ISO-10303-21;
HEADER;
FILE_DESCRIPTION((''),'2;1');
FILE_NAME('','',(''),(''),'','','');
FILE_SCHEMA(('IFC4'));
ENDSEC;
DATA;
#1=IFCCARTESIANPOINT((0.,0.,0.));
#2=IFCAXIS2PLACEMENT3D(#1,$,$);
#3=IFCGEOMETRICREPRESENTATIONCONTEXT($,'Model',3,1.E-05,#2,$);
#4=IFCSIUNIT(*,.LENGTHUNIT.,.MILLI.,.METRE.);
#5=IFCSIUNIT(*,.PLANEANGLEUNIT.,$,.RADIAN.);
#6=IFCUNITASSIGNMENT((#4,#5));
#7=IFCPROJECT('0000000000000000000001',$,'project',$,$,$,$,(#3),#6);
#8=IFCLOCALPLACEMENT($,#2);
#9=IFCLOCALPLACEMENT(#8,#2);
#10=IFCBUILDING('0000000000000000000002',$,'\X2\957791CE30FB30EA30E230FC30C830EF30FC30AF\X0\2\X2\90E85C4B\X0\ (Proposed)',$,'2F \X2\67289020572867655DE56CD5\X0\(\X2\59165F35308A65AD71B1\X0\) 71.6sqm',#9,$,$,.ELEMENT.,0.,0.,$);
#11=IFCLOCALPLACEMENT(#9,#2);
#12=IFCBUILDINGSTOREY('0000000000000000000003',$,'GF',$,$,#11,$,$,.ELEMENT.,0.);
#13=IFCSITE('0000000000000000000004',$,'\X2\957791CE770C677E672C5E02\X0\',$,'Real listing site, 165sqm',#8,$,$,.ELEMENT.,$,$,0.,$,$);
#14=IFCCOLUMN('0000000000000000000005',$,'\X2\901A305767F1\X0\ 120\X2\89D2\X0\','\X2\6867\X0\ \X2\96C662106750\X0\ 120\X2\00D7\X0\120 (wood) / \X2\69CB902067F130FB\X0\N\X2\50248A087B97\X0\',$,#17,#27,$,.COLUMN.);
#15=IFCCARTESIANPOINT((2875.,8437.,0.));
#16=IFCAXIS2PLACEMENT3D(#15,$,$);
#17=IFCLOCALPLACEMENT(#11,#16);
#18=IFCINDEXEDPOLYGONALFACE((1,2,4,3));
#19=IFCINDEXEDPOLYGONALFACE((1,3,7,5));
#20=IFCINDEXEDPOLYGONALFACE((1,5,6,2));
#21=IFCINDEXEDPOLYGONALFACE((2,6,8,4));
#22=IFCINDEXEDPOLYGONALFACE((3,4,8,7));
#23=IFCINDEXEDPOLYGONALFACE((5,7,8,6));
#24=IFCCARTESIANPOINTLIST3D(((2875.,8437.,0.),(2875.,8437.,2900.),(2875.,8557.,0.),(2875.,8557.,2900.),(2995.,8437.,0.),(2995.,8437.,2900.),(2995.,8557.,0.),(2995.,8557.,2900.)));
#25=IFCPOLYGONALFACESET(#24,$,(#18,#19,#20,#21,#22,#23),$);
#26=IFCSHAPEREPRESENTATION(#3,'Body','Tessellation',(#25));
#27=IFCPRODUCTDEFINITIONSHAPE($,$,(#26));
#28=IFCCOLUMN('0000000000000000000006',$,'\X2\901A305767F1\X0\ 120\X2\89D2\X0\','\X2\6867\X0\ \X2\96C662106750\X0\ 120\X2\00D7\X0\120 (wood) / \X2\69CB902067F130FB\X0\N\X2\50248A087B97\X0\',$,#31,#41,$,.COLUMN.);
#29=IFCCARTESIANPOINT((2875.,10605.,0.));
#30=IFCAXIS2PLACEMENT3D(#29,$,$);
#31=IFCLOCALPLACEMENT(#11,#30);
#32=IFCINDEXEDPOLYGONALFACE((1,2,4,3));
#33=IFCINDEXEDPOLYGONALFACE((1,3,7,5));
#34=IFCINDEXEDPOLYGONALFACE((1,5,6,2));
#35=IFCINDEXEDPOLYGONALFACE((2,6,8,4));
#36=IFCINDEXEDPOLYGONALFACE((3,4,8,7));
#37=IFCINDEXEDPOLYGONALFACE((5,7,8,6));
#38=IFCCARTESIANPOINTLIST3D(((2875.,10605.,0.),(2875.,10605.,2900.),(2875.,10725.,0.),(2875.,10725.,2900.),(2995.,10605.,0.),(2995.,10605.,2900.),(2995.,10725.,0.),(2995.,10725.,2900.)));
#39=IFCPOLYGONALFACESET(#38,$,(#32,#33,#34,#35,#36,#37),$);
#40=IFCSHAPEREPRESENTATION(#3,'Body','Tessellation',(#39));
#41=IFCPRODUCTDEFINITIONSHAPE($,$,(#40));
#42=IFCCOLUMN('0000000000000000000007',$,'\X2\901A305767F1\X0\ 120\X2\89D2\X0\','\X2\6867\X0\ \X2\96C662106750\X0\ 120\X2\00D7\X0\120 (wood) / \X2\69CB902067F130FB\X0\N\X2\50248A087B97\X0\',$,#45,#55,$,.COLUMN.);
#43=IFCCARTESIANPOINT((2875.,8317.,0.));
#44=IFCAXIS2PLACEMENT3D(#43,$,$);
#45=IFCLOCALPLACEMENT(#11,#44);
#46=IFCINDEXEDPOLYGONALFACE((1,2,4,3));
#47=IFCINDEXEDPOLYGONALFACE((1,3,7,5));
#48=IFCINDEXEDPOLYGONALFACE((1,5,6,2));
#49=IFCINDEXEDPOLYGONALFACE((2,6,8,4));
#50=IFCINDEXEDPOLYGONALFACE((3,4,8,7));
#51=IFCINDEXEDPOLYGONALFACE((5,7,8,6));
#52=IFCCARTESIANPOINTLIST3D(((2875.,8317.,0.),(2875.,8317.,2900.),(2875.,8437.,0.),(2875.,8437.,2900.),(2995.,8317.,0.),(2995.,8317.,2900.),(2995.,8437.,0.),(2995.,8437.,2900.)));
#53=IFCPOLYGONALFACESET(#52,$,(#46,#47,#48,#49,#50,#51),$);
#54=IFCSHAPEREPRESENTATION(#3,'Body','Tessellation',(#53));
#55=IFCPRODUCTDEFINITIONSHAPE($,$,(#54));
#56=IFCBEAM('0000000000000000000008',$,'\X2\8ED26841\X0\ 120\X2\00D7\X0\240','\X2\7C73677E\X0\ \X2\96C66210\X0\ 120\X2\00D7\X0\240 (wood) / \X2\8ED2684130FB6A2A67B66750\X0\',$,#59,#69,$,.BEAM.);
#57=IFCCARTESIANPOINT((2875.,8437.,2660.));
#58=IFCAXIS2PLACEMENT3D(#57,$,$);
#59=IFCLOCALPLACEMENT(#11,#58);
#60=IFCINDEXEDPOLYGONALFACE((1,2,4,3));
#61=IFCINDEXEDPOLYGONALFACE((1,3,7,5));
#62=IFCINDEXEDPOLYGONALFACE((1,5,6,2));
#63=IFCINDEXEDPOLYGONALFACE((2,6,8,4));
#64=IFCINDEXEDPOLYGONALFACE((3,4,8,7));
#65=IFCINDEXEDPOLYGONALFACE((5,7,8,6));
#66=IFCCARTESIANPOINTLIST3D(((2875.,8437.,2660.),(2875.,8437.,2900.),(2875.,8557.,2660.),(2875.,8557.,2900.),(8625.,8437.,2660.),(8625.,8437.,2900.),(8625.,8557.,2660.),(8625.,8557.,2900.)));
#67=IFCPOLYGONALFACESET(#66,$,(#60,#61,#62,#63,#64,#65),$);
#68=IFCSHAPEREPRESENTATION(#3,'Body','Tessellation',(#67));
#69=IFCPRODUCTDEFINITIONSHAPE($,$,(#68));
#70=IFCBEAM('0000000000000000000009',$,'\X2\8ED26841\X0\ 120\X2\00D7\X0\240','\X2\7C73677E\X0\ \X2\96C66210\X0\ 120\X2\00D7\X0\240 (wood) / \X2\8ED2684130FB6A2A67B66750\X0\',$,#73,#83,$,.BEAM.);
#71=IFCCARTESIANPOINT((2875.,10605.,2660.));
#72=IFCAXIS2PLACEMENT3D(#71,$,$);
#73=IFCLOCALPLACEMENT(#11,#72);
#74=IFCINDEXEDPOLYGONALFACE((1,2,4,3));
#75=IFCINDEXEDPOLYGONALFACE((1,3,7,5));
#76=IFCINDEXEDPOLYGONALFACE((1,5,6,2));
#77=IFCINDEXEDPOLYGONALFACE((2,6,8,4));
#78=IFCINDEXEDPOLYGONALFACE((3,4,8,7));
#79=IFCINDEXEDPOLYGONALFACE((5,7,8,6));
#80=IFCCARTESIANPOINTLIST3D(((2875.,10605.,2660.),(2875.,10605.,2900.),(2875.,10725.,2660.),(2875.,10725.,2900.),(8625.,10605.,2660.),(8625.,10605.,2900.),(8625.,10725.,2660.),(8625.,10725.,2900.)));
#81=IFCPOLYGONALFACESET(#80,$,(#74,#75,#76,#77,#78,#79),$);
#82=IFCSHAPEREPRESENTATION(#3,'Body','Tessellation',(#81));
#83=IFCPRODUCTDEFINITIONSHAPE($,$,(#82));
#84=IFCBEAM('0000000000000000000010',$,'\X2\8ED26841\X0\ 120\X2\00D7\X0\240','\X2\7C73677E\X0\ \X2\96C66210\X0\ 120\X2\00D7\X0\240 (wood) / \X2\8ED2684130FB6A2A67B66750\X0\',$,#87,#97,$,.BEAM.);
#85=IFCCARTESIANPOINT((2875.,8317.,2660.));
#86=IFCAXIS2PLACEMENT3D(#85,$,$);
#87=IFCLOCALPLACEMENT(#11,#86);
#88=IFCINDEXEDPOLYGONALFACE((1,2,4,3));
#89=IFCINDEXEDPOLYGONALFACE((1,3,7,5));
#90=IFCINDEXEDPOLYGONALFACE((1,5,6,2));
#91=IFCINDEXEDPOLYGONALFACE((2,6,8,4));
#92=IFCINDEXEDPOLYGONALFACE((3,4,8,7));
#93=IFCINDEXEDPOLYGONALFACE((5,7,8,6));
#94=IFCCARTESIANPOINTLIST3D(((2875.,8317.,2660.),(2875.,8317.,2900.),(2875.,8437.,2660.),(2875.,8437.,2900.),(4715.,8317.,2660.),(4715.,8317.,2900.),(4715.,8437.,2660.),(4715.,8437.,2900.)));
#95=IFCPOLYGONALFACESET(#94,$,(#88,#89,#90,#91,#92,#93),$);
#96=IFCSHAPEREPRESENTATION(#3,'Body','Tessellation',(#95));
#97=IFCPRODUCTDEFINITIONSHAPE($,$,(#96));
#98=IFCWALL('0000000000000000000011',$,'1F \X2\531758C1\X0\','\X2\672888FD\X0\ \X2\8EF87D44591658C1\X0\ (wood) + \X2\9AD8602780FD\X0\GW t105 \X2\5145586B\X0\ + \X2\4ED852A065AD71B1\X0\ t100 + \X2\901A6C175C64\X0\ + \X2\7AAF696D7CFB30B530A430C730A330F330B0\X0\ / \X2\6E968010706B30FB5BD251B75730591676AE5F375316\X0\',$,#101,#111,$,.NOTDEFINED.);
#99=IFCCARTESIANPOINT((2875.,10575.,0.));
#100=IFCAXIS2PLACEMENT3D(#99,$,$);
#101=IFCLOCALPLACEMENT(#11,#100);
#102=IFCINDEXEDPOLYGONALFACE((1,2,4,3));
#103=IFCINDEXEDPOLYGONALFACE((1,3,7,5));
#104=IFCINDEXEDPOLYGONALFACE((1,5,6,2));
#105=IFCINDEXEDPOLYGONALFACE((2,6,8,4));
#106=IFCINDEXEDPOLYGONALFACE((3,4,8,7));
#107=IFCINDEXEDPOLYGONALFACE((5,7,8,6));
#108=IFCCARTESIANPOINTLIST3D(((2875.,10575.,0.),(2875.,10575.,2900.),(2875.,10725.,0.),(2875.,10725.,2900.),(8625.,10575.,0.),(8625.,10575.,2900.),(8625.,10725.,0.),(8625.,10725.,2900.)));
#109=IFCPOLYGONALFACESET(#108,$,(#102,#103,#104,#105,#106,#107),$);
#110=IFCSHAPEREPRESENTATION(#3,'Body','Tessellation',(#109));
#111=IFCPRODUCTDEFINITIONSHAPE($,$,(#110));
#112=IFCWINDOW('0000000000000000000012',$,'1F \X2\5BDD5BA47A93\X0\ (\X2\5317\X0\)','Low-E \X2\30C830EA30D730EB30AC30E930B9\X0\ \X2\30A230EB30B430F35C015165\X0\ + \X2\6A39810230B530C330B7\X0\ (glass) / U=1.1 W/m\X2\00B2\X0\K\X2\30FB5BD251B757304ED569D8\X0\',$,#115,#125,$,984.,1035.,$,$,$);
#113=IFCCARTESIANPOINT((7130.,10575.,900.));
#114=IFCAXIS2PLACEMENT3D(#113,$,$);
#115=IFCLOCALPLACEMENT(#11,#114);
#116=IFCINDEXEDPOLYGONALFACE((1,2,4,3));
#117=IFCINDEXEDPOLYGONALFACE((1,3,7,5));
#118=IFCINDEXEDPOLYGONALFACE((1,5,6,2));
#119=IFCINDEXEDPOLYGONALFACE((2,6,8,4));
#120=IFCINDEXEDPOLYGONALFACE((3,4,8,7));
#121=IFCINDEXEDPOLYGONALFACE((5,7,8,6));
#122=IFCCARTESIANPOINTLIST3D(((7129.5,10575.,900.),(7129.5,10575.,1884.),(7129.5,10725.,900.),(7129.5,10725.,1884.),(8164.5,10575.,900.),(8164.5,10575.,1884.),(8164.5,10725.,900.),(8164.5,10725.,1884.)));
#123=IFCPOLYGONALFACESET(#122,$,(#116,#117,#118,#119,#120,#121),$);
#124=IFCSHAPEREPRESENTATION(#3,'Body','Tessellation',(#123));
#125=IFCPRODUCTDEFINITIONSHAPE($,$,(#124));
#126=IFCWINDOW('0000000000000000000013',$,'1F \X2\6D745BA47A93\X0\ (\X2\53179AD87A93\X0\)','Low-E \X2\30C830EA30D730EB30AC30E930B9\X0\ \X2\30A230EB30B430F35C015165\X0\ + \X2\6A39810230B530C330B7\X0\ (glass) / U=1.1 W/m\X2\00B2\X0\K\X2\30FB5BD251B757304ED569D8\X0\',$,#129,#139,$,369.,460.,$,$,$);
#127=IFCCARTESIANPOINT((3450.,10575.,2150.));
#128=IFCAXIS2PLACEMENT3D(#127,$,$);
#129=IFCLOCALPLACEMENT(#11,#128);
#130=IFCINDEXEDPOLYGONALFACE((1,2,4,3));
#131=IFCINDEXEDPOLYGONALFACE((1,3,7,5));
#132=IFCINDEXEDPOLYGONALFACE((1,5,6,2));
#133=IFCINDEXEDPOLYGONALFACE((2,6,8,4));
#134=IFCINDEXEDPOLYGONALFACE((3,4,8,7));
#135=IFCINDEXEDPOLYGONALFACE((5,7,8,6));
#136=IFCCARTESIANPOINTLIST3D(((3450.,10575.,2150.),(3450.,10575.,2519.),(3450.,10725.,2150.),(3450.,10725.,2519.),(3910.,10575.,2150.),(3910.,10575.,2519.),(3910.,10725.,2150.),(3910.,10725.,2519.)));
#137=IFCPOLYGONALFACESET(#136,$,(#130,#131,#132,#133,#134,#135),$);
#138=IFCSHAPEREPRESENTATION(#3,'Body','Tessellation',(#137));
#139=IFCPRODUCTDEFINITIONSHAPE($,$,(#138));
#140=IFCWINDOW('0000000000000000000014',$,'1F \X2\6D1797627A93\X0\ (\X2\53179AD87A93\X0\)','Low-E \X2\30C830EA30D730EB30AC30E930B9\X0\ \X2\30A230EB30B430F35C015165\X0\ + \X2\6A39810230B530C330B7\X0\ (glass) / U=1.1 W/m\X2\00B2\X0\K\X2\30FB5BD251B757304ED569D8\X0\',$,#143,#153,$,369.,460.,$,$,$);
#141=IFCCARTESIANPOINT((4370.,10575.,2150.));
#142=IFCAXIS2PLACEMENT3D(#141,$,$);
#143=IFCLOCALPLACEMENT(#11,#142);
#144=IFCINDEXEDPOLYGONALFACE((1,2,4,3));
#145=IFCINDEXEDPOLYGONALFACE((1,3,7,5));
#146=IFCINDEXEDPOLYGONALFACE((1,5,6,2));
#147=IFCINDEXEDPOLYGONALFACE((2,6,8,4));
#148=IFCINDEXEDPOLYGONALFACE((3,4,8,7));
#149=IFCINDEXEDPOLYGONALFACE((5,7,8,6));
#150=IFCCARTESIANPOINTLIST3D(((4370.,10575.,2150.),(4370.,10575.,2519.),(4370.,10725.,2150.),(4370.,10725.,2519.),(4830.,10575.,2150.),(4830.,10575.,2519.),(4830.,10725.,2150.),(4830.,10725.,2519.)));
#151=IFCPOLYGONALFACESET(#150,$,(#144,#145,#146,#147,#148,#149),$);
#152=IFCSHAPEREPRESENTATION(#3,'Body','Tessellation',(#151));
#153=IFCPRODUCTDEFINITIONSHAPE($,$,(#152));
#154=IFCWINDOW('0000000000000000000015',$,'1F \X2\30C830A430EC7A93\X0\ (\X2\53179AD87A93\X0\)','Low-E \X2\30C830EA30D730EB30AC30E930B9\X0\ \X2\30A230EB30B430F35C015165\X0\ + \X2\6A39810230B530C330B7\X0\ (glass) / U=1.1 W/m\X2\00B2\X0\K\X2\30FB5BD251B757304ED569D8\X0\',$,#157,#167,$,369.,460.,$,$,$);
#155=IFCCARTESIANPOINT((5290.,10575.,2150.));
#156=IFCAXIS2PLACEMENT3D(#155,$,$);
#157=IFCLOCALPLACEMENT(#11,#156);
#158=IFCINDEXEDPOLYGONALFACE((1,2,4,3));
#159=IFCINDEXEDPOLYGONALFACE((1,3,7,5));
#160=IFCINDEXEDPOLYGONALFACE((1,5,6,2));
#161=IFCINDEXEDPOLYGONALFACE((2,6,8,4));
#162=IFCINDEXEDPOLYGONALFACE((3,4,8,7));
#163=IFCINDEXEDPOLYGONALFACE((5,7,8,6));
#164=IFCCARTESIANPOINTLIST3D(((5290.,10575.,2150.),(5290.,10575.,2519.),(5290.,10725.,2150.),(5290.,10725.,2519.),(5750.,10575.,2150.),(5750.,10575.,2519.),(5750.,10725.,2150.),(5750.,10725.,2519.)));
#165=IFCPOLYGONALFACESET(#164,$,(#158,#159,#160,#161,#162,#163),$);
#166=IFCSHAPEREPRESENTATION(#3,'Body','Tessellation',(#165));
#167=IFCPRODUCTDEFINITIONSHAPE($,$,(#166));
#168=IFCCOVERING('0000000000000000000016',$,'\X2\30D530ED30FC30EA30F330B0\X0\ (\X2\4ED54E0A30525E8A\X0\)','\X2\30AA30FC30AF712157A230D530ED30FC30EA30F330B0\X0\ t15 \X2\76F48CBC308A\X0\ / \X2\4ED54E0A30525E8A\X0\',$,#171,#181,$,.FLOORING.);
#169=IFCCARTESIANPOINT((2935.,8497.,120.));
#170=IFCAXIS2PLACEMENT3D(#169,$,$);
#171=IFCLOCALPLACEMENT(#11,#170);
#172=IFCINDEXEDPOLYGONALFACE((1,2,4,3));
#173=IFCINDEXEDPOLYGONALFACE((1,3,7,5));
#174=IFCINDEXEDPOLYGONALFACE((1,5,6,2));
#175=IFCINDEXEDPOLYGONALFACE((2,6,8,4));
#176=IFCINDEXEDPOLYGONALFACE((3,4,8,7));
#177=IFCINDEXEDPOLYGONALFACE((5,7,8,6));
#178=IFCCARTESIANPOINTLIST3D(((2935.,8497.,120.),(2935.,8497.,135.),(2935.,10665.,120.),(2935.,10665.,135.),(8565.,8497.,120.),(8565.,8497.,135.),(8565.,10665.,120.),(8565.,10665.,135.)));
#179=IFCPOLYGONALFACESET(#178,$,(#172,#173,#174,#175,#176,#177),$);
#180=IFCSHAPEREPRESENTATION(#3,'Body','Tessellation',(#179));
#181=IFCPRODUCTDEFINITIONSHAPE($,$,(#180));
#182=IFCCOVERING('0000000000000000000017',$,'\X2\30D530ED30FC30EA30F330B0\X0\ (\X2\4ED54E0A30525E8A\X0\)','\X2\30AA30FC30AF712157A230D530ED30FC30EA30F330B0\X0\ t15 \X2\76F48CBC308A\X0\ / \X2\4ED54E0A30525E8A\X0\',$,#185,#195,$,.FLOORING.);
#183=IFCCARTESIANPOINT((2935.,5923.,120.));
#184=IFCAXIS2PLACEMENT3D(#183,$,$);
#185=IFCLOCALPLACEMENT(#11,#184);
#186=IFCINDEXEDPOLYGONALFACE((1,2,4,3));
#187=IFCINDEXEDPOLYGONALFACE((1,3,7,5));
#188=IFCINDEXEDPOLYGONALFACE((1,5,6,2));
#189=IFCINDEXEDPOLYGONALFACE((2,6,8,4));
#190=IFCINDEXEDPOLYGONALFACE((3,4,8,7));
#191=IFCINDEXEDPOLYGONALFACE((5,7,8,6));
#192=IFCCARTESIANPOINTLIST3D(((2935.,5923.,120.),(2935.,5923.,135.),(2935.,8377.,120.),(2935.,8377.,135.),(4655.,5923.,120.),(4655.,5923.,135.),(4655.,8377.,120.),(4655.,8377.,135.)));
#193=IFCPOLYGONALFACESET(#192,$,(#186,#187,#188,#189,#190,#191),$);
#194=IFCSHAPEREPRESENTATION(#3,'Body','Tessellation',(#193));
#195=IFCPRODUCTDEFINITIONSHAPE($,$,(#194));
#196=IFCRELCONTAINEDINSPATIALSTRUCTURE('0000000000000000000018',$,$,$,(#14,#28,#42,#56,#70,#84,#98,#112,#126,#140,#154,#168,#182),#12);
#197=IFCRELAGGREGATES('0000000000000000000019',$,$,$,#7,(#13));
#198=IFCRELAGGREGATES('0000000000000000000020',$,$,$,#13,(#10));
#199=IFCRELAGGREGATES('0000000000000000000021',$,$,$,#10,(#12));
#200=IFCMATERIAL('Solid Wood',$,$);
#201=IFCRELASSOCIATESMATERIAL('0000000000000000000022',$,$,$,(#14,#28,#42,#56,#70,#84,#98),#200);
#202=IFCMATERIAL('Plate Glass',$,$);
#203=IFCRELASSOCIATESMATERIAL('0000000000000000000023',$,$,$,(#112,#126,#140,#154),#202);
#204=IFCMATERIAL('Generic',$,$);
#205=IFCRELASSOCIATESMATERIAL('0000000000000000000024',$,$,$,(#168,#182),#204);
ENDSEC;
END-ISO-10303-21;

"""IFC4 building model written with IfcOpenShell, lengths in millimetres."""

from ifc_helpers import new_model, si_unit, frame, frame_2d, origin, place, context, project, spatial, rectangle, extrude, material, element, fill, save


model = new_model("IFC4")

# Units and contexts
model_context = context("Model", 3, precision=1e-05, world=origin())
ifc_project = project(units=[si_unit("LENGTHUNIT", "METRE", prefix="MILLI"), si_unit("PLANEANGLEUNIT", "RADIAN")], contexts=[model_context])

# Site, building, storey
site_placement = place(None, origin())
site = spatial("IfcSite", under=ifc_project, at=site_placement, Name="長野県松本市", ObjectType="Real listing site, 165sqm", CompositionType="ELEMENT", RefElevation=0.0)
building_placement = place(site_placement, origin())
building = spatial("IfcBuilding", under=site, at=building_placement, Name="長野・リモートワーク2部屋 (Proposed)", ObjectType="2F 木造在来工法(外張り断熱) 71.6sqm", CompositionType="ELEMENT", ElevationOfRefHeight=0.0, ElevationOfTerrain=0.0)
storey_placement = place(building_placement, origin())
storey = spatial("IfcBuildingStorey", under=building, at=storey_placement, Name="GF", CompositionType="ELEMENT", Elevation=0.0)

# Columns
ifc_material_1 = material(Name="Solid Wood")
column_1_placement = place(storey_placement, frame((2875.0, 8437.0, 0.0)))
element("IfcColumn", 1, at=column_1_placement, inside=storey, material=ifc_material_1, Name="通し柱 120角", Description="桧 集成材 120×120 (wood) / 構造柱・N値計算", PredefinedType="COLUMN", context=model_context, shape_type="SweptSolid", body=[
    extrude(rectangle(XDim=120.0, YDim=120.0, at=frame_2d((60.0, 60.0))), frame((2875.0, 8437.0, 0.0)), (0.0, 0.0, 1.0), 2900.0),
])
column_2_placement = place(storey_placement, frame((2875.0, 10605.0, 0.0)))
element("IfcColumn", 2, at=column_2_placement, inside=storey, material=ifc_material_1, Name="通し柱 120角", Description="桧 集成材 120×120 (wood) / 構造柱・N値計算", PredefinedType="COLUMN", context=model_context, shape_type="SweptSolid", body=[
    extrude(rectangle(XDim=120.0, YDim=120.0, at=frame_2d((60.0, 60.0))), frame((2875.0, 10605.0, 0.0)), (0.0, 0.0, 1.0), 2900.0),
])
column_3_placement = place(storey_placement, frame((2875.0, 8317.0, 0.0)))
element("IfcColumn", 3, at=column_3_placement, inside=storey, material=ifc_material_1, Name="通し柱 120角", Description="桧 集成材 120×120 (wood) / 構造柱・N値計算", PredefinedType="COLUMN", context=model_context, shape_type="SweptSolid", body=[
    extrude(rectangle(XDim=120.0, YDim=120.0, at=frame_2d((60.0, 60.0))), frame((2875.0, 8317.0, 0.0)), (0.0, 0.0, 1.0), 2900.0),
])

# Beams
beam_1_placement = place(storey_placement, frame((2875.0, 8437.0, 2660.0)))
element("IfcBeam", 4, at=beam_1_placement, inside=storey, material=ifc_material_1, Name="軒桁 120×240", Description="米松 集成 120×240 (wood) / 軒桁・横架材", PredefinedType="BEAM", context=model_context, shape_type="SweptSolid", body=[
    extrude(rectangle(XDim=5750.0, YDim=120.0, at=frame_2d((2875.0, 60.0))), frame((2875.0, 8437.0, 2660.0)), (0.0, 0.0, 1.0), 240.0),
])
beam_2_placement = place(storey_placement, frame((2875.0, 10605.0, 2660.0)))
element("IfcBeam", 5, at=beam_2_placement, inside=storey, material=ifc_material_1, Name="軒桁 120×240", Description="米松 集成 120×240 (wood) / 軒桁・横架材", PredefinedType="BEAM", context=model_context, shape_type="SweptSolid", body=[
    extrude(rectangle(XDim=5750.0, YDim=120.0, at=frame_2d((2875.0, 60.0))), frame((2875.0, 10605.0, 2660.0)), (0.0, 0.0, 1.0), 240.0),
])
beam_3_placement = place(storey_placement, frame((2875.0, 8317.0, 2660.0)))
element("IfcBeam", 6, at=beam_3_placement, inside=storey, material=ifc_material_1, Name="軒桁 120×240", Description="米松 集成 120×240 (wood) / 軒桁・横架材", PredefinedType="BEAM", context=model_context, shape_type="SweptSolid", body=[
    extrude(rectangle(XDim=1840.0, YDim=120.0, at=frame_2d((920.0, 60.0))), frame((2875.0, 8317.0, 2660.0)), (0.0, 0.0, 1.0), 240.0),
])

# Wall, openings, windows
wall_1_placement = place(storey_placement, frame((2875.0, 10575.0, 0.0)))
wall_1 = element("IfcWall", 7, at=wall_1_placement, inside=storey, material=ifc_material_1, Name="1F 北壁", Description="木製 軸組外壁 (wood) + 高性能GW t105 充填 + 付加断熱 t100 + 通気層 + 窯業系サイディング / 準耐火・寒冷地外皮強化", PredefinedType="NOTDEFINED", context=model_context, shape_type="SweptSolid", body=[
    extrude(rectangle(XDim=5750.0, YDim=150.0, at=frame_2d((2875.0, 75.0))), frame((2875.0, 10575.0, 0.0)), (0.0, 0.0, 1.0), 2900.0),
])
opening_1_placement = place(storey_placement, frame((7130.0, 10575.0, 900.0)))
opening_1 = element("IfcOpeningElement", 8, at=opening_1_placement, cuts=wall_1, PredefinedType="NOTDEFINED", context=model_context, shape_type="SweptSolid", body=[
    extrude(rectangle(XDim=1035.0, YDim=150.0, at=frame_2d((517.0, 75.0))), frame((7130.0, 10575.0, 900.0)), (0.0, 0.0, 1.0), 984.0),
])
opening_2_placement = place(storey_placement, frame((3450.0, 10575.0, 2150.0)))
opening_2 = element("IfcOpeningElement", 9, at=opening_2_placement, cuts=wall_1, PredefinedType="NOTDEFINED", context=model_context, shape_type="SweptSolid", body=[
    extrude(rectangle(XDim=460.0, YDim=150.0, at=frame_2d((230.0, 75.0))), frame((3450.0, 10575.0, 2150.0)), (0.0, 0.0, 1.0), 369.0),
])
opening_3_placement = place(storey_placement, frame((4370.0, 10575.0, 2150.0)))
opening_3 = element("IfcOpeningElement", 10, at=opening_3_placement, cuts=wall_1, PredefinedType="NOTDEFINED", context=model_context, shape_type="SweptSolid", body=[
    extrude(rectangle(XDim=460.0, YDim=150.0, at=frame_2d((230.0, 75.0))), frame((4370.0, 10575.0, 2150.0)), (0.0, 0.0, 1.0), 369.0),
])
opening_4_placement = place(storey_placement, frame((5290.0, 10575.0, 2150.0)))
opening_4 = element("IfcOpeningElement", 11, at=opening_4_placement, cuts=wall_1, PredefinedType="NOTDEFINED", context=model_context, shape_type="SweptSolid", body=[
    extrude(rectangle(XDim=460.0, YDim=150.0, at=frame_2d((230.0, 75.0))), frame((5290.0, 10575.0, 2150.0)), (0.0, 0.0, 1.0), 369.0),
])
ifc_material_2 = material(Name="Plate Glass")
window_1_placement = place(storey_placement, frame((7130.0, 10575.0, 900.0)))
window_1 = element("IfcWindow", 12, at=window_1_placement, inside=storey, material=ifc_material_2, Name="1F 寝室窓 (北)", Description="Low-E トリプルガラス アルゴン封入 + 樹脂サッシ (glass) / U=1.1 W/m²K・寒冷地仕様", OverallHeight=984.0, OverallWidth=1035.0, context=model_context, shape_type="SweptSolid", body=[
    extrude(rectangle(XDim=1035.0, YDim=150.0, at=frame_2d((517.0, 75.0))), frame((7130.0, 10575.0, 900.0)), (0.0, 0.0, 1.0), 984.0),
])
fill(opening_1, window_1)
window_2_placement = place(storey_placement, frame((3450.0, 10575.0, 2150.0)))
window_2 = element("IfcWindow", 13, at=window_2_placement, inside=storey, material=ifc_material_2, Name="1F 浴室窓 (北高窓)", Description="Low-E トリプルガラス アルゴン封入 + 樹脂サッシ (glass) / U=1.1 W/m²K・寒冷地仕様", OverallHeight=369.0, OverallWidth=460.0, context=model_context, shape_type="SweptSolid", body=[
    extrude(rectangle(XDim=460.0, YDim=150.0, at=frame_2d((230.0, 75.0))), frame((3450.0, 10575.0, 2150.0)), (0.0, 0.0, 1.0), 369.0),
])
fill(opening_2, window_2)
window_3_placement = place(storey_placement, frame((4370.0, 10575.0, 2150.0)))
window_3 = element("IfcWindow", 14, at=window_3_placement, inside=storey, material=ifc_material_2, Name="1F 洗面窓 (北高窓)", Description="Low-E トリプルガラス アルゴン封入 + 樹脂サッシ (glass) / U=1.1 W/m²K・寒冷地仕様", OverallHeight=369.0, OverallWidth=460.0, context=model_context, shape_type="SweptSolid", body=[
    extrude(rectangle(XDim=460.0, YDim=150.0, at=frame_2d((230.0, 75.0))), frame((4370.0, 10575.0, 2150.0)), (0.0, 0.0, 1.0), 369.0),
])
fill(opening_3, window_3)
window_4_placement = place(storey_placement, frame((5290.0, 10575.0, 2150.0)))
window_4 = element("IfcWindow", 15, at=window_4_placement, inside=storey, material=ifc_material_2, Name="1F トイレ窓 (北高窓)", Description="Low-E トリプルガラス アルゴン封入 + 樹脂サッシ (glass) / U=1.1 W/m²K・寒冷地仕様", OverallHeight=369.0, OverallWidth=460.0, context=model_context, shape_type="SweptSolid", body=[
    extrude(rectangle(XDim=460.0, YDim=150.0, at=frame_2d((230.0, 75.0))), frame((5290.0, 10575.0, 2150.0)), (0.0, 0.0, 1.0), 369.0),
])
fill(opening_4, window_4)

# Coverings
ifc_material_3 = material(Name="Generic")
covering_1_placement = place(storey_placement, frame((2935.0, 8497.0, 120.0)))
element("IfcCovering", 16, at=covering_1_placement, inside=storey, material=ifc_material_3, Name="フローリング (仕上げ床)", Description="オーク無垢フローリング t15 直貼り / 仕上げ床", PredefinedType="FLOORING", context=model_context, shape_type="SweptSolid", body=[
    extrude(rectangle(XDim=5630.0, YDim=2168.0, at=frame_2d((2815.0, 1084.0))), frame((2935.0, 8497.0, 120.0)), (0.0, 0.0, 1.0), 15.0),
])
covering_2_placement = place(storey_placement, frame((2935.0, 5923.0, 120.0)))
element("IfcCovering", 17, at=covering_2_placement, inside=storey, material=ifc_material_3, Name="フローリング (仕上げ床)", Description="オーク無垢フローリング t15 直貼り / 仕上げ床", PredefinedType="FLOORING", context=model_context, shape_type="SweptSolid", body=[
    extrude(rectangle(XDim=1720.0, YDim=2454.0, at=frame_2d((860.0, 1227.0))), frame((2935.0, 5923.0, 120.0)), (0.0, 0.0, 1.0), 15.0),
])

save(model, "model.ifc")
